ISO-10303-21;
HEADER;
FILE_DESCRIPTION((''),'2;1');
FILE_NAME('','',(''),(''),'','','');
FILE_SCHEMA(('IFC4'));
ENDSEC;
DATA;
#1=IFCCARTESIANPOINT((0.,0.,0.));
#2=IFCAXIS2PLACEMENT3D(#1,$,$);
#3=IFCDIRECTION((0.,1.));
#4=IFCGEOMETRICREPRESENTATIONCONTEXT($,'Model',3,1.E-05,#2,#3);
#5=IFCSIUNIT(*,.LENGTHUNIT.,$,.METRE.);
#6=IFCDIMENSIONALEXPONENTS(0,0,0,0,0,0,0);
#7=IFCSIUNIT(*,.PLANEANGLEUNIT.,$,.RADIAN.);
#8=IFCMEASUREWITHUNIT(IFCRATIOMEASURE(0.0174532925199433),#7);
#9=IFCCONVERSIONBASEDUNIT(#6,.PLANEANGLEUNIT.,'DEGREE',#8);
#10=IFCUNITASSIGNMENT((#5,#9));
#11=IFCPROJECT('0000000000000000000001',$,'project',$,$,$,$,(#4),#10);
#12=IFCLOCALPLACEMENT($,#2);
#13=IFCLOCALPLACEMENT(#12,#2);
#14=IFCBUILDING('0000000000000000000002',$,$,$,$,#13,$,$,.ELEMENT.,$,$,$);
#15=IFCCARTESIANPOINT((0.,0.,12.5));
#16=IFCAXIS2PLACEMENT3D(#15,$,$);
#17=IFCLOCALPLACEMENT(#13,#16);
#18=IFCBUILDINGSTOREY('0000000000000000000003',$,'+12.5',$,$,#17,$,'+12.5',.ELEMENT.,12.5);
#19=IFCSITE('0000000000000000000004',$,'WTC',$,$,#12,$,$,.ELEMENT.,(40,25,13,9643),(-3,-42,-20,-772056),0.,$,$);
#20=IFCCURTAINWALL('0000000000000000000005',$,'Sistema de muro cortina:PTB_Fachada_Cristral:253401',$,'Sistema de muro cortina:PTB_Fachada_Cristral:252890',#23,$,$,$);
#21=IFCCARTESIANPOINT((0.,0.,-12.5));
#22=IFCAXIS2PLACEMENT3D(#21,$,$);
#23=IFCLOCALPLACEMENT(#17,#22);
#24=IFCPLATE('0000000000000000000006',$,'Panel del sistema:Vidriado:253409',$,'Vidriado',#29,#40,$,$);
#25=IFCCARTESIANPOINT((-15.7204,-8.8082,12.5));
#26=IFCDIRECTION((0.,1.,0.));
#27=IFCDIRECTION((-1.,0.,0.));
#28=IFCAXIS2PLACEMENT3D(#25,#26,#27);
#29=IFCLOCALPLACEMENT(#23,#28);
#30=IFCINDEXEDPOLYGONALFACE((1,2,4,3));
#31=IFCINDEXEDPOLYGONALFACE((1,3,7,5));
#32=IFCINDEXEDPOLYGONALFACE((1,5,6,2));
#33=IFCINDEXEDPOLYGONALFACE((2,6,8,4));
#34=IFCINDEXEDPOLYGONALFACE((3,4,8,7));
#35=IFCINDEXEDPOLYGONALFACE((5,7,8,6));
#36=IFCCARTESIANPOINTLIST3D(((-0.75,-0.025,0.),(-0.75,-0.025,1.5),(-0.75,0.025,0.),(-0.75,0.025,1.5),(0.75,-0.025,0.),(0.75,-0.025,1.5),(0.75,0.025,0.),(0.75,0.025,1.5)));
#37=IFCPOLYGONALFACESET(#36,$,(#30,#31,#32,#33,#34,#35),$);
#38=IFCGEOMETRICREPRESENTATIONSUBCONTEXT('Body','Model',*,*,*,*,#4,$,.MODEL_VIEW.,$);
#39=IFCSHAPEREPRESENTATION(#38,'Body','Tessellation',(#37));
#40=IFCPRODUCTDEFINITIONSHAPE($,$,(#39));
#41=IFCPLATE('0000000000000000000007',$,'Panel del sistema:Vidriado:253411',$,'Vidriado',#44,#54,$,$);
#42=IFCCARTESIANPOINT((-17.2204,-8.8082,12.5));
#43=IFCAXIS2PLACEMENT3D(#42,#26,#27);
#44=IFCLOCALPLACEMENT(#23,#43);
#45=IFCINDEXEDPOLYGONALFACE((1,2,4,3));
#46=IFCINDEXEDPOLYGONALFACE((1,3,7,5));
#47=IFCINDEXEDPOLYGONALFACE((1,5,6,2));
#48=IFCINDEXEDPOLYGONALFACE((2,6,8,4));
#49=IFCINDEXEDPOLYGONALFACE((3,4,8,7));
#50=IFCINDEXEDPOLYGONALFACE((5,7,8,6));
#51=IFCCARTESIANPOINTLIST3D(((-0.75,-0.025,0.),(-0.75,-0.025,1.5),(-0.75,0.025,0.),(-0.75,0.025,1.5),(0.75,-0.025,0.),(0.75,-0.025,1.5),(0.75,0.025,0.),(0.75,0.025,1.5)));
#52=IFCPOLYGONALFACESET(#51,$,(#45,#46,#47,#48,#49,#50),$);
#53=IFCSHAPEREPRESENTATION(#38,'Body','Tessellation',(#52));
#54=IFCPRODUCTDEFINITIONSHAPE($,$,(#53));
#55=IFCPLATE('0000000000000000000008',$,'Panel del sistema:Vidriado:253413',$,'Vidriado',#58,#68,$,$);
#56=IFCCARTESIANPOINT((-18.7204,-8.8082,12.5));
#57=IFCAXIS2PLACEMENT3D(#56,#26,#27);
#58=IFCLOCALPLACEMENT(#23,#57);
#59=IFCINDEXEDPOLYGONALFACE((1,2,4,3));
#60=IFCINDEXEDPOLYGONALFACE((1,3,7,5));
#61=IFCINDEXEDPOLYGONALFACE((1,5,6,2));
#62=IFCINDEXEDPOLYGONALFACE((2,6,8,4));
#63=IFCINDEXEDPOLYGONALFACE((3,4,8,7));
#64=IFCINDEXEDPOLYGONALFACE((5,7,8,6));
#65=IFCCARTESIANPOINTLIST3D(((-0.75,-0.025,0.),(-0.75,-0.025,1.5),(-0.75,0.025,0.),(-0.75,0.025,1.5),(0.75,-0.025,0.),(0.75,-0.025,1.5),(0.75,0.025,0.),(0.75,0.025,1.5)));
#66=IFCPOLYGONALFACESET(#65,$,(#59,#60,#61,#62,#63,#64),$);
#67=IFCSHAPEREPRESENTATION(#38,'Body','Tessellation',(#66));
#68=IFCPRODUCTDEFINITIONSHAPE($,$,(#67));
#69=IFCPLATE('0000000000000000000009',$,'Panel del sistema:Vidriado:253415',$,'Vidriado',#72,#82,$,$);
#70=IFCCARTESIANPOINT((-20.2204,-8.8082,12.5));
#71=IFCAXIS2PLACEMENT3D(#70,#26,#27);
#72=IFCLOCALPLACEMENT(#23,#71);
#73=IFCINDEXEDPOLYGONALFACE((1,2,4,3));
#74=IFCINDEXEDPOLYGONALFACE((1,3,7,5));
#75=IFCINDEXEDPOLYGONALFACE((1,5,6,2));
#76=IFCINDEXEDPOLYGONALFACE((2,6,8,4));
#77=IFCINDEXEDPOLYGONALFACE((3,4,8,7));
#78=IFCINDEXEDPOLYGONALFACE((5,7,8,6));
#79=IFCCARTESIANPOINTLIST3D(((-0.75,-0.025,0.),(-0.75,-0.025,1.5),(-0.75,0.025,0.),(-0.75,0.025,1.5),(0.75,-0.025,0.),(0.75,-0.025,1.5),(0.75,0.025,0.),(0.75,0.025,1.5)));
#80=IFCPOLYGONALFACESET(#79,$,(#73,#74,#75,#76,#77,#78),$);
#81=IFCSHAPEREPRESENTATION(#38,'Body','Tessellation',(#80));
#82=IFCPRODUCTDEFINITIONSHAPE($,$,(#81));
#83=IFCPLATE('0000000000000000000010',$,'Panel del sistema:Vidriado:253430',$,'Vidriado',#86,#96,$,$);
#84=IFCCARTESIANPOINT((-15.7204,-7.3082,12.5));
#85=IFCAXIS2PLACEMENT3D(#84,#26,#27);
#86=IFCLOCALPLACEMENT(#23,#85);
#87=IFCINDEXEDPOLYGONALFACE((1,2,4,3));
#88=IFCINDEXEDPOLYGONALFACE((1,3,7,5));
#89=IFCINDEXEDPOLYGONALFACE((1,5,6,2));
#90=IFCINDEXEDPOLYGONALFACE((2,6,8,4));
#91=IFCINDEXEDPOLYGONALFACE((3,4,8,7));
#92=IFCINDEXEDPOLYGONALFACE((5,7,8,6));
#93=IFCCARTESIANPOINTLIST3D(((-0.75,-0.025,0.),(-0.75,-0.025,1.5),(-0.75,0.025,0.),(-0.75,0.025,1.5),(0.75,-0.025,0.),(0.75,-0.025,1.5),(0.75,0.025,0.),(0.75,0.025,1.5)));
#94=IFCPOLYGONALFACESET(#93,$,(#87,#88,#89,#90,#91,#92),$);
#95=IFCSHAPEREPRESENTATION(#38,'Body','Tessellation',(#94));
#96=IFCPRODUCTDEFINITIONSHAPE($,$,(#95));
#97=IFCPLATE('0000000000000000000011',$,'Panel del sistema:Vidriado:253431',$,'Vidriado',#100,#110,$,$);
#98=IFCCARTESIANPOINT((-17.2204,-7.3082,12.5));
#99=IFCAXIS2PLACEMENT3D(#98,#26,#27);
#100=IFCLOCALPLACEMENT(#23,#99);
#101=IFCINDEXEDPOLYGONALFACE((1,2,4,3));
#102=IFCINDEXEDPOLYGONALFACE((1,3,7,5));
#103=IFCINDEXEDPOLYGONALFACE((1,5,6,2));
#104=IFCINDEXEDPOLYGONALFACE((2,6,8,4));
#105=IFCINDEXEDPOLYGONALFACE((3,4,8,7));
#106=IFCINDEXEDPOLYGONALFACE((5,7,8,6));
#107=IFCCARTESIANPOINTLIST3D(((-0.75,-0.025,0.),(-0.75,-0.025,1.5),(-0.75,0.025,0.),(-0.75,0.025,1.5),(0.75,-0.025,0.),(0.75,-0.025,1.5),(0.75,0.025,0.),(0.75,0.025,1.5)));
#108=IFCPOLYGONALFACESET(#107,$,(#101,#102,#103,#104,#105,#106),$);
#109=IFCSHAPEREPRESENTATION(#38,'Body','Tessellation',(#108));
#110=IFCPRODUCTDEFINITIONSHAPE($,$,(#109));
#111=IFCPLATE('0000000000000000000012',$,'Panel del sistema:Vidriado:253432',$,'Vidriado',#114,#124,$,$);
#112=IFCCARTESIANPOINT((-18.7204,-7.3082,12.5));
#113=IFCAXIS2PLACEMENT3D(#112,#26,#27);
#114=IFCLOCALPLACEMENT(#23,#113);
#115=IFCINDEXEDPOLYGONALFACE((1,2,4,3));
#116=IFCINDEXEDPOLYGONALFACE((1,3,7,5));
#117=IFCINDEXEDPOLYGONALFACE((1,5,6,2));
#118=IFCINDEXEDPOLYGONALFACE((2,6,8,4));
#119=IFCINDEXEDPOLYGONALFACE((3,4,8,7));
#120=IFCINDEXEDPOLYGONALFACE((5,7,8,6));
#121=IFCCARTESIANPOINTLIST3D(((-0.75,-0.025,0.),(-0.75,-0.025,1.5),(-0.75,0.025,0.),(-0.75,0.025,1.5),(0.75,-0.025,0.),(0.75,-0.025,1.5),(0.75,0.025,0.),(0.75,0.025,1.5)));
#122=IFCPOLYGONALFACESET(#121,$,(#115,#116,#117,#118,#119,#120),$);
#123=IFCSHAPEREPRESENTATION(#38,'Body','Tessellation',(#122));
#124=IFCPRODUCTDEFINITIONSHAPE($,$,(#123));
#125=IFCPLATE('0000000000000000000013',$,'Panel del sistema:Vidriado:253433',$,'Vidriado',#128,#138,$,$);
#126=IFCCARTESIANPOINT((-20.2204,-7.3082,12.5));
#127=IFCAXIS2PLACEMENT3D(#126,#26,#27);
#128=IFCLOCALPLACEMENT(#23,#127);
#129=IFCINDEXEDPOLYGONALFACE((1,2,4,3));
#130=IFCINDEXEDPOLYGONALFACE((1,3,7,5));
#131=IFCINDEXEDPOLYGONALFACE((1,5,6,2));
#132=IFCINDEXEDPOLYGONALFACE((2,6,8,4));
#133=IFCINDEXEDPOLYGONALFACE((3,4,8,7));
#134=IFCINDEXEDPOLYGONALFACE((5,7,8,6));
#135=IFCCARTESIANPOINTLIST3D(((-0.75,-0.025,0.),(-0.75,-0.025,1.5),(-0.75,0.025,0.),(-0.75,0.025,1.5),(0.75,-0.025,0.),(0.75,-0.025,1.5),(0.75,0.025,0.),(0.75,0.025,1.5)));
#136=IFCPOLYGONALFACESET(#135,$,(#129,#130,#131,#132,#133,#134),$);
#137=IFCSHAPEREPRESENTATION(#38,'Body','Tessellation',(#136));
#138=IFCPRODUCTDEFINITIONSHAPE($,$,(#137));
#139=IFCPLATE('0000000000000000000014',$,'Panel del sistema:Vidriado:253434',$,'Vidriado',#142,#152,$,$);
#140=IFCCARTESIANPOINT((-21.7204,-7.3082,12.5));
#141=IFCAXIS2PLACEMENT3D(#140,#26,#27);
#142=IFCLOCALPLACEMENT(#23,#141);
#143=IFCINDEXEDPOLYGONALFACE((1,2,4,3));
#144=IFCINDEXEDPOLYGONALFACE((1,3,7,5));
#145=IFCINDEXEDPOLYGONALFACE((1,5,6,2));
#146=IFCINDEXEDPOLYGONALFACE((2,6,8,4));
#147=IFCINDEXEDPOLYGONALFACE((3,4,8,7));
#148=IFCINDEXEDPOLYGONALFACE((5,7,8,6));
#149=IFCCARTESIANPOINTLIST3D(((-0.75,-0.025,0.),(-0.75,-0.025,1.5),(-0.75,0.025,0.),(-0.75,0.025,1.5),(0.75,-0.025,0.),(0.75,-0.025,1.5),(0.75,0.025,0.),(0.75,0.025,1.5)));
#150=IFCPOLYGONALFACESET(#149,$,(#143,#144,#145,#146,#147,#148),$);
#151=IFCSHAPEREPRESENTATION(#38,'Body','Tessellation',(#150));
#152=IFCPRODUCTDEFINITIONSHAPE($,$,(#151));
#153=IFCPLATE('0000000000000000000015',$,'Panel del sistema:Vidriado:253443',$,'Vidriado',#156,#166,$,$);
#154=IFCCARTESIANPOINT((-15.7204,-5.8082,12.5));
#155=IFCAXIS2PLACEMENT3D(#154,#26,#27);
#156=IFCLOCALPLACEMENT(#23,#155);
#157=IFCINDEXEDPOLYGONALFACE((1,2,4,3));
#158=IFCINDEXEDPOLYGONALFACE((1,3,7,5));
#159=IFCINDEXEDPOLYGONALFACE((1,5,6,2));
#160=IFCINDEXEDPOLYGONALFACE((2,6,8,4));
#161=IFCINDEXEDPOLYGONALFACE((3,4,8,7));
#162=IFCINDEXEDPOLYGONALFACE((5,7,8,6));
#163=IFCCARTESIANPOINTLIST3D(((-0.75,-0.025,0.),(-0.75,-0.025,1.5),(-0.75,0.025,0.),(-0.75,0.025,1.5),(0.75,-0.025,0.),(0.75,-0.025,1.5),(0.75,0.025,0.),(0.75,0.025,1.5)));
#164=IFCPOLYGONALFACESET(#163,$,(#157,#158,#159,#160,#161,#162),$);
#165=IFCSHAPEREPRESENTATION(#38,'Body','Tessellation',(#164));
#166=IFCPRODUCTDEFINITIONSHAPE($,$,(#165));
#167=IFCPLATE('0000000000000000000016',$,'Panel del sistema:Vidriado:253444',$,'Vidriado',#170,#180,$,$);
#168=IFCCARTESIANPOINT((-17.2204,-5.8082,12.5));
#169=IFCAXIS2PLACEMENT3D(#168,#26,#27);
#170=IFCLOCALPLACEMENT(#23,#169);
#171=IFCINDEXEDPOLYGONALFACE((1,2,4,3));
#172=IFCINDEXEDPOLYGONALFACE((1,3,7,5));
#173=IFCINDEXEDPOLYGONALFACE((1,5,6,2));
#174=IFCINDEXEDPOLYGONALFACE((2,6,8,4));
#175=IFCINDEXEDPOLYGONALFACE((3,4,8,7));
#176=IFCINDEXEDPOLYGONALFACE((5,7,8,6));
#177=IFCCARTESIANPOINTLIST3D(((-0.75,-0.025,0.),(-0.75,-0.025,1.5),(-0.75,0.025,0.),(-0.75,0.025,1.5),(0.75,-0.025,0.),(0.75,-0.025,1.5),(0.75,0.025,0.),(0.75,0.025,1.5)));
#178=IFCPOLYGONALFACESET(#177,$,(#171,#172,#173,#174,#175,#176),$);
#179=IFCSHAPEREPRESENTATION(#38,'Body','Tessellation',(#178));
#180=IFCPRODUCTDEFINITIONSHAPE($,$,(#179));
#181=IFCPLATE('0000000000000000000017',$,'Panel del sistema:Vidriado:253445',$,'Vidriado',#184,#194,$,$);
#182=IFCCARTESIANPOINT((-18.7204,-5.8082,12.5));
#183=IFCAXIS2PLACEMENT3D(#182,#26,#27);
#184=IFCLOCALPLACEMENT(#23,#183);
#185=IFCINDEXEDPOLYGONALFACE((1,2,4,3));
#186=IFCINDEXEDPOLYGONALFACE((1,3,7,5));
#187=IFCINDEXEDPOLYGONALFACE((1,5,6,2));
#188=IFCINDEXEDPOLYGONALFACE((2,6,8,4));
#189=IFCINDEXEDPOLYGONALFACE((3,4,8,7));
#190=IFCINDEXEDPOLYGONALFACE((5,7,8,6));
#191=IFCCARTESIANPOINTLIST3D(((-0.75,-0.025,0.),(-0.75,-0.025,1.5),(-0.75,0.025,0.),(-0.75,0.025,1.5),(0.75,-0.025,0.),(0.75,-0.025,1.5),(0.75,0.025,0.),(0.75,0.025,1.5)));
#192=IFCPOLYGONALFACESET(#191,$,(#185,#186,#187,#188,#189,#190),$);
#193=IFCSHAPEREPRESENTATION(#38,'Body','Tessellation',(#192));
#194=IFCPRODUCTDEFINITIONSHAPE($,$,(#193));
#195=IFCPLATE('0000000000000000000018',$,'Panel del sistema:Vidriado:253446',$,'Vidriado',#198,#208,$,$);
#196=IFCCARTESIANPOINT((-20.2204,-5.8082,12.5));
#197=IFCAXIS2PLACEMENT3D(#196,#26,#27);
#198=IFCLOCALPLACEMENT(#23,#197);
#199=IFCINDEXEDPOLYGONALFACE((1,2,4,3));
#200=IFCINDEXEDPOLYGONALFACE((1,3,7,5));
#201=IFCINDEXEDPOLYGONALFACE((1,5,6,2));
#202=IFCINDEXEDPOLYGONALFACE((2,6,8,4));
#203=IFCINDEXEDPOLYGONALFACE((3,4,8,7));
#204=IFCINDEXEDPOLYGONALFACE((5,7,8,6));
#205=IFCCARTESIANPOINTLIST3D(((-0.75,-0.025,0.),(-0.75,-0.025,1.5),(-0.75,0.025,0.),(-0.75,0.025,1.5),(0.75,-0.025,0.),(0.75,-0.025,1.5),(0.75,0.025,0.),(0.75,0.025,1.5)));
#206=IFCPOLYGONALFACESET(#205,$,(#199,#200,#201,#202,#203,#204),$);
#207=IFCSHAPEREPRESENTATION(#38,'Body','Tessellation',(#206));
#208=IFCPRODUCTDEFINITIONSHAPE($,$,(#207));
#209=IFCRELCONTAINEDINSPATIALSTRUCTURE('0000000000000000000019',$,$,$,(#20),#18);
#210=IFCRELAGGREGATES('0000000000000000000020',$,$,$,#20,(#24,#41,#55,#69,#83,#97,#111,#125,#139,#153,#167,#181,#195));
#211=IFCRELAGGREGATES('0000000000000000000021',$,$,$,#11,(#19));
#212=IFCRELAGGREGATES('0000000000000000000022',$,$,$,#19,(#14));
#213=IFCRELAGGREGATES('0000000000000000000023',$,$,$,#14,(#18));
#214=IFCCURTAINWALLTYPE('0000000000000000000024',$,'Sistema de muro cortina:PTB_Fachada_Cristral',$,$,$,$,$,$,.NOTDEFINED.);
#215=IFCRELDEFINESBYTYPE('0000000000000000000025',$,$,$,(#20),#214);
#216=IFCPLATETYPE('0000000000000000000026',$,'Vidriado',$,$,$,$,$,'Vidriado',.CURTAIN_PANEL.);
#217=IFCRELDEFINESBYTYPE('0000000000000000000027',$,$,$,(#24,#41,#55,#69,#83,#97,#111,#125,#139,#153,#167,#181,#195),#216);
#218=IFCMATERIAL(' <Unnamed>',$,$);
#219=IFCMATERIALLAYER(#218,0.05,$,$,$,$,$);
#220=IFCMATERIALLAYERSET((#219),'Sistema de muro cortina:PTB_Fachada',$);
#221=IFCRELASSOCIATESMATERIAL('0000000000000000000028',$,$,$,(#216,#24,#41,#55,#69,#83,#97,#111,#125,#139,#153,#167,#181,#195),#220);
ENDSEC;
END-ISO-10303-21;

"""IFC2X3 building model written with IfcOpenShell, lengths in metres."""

from ifc_helpers import new_model, entity, si_unit, converted_unit, direction, frame, origin, origin_2d_with_axis, place, context, subcontext, project, spatial, rectangle, extrude, source, transform, mapped, material, layer, layer_set, layer_usage, type_object, type_shapes, element, aggregate, save


model = new_model("IFC2X3")

# Units and contexts
model_context = context("Model", 3, precision=1e-05, world=origin(), true_north=direction((0.0, 1.0)))
body_context = subcontext(model_context, "Body", "Model", "MODEL_VIEW")
ifc_project = project(units=[si_unit("LENGTHUNIT", "METRE"), converted_unit("PLANEANGLEUNIT", "DEGREE", entity("IfcRatioMeasure", 0.0174532925199433), si_unit("PLANEANGLEUNIT", "RADIAN"), dimensions=[0, 0, 0, 0, 0, 0, 0])], contexts=[model_context])

# Site, building, storey
site_placement = place(None, origin())
site = spatial("IfcSite", under=ifc_project, at=site_placement, Name="WTC", CompositionType="ELEMENT", RefLatitude=(40, 25, 13, 9643), RefLongitude=(-3, -42, -20, -772056), RefElevation=0.0)
building_placement = place(site_placement, origin())
building = spatial("IfcBuilding", under=site, at=building_placement, CompositionType="ELEMENT")
storey_placement = place(building_placement, frame((0.0, 0.0, 12.5)))
storey = spatial("IfcBuildingStorey", under=building, at=storey_placement, Name="+12.5", LongName="+12.5", CompositionType="ELEMENT", Elevation=12.5)

# Curtain wall, plates
curtain_wall_type = type_object("IfcCurtainWallType", Name="Sistema de muro cortina:PTB_Fachada_Cristral", PredefinedType="NOTDEFINED")
curtain_wall_placement = place(storey_placement, frame((0.0, 0.0, -12.5)))
curtain_wall = element("IfcCurtainWall", 1, at=curtain_wall_placement, inside=storey, type_object=curtain_wall_type, Name="Sistema de muro cortina:PTB_Fachada_Cristral:253401", ObjectType="Sistema de muro cortina:PTB_Fachada_Cristral:252890")
ifc_material = material(Name=" <Unnamed>")
ifc_layer = layer(ifc_material, 0.05)
ifc_layer_set = layer_set([ifc_layer], Name="Sistema de muro cortina:PTB_Fachada")
ifc_layer_usage_1 = layer_usage(ifc_layer_set, "AXIS3", "POSITIVE", 0.0)
plate_type = type_object("IfcPlateType", Name="Vidriado", ElementType="Vidriado", PredefinedType="CURTAIN_PANEL", material=ifc_layer_set)
shared_shape = source(origin(), body_context, "Body", "SweptSolid", [
    extrude(rectangle(XDim=0.05, YDim=1.5, at=origin_2d_with_axis()), frame((0.0, 0.0, 0.0), z_axis=(0.0, 0.0, 1.0), x_axis=(0.0, 1.0, 0.0)), (0.0, 0.0, 1.0), 1.5),
])
type_shapes(plate_type, [shared_shape])
plate_1_placement = place(curtain_wall_placement, frame((-15.7204, -8.8082, 12.5), z_axis=(0.0, 1.0, 0.0), x_axis=(-1.0, 0.0, 0.0)))
plate_1 = element("IfcPlate", 2, at=plate_1_placement, type_object=plate_type, material=ifc_layer_usage_1, Name="Panel del sistema:Vidriado:253409", ObjectType="Vidriado", context=body_context, shape_type="MappedRepresentation", body=[
    mapped(shared_shape, transform((0.0, 0.0, 0.0), scale=1.0)),
])
ifc_layer_usage_2 = layer_usage(ifc_layer_set, "AXIS3", "POSITIVE", 0.0)
plate_2_placement = place(curtain_wall_placement, frame((-17.2204, -8.8082, 12.5), z_axis=(0.0, 1.0, 0.0), x_axis=(-1.0, 0.0, 0.0)))
plate_2 = element("IfcPlate", 3, at=plate_2_placement, type_object=plate_type, material=ifc_layer_usage_2, Name="Panel del sistema:Vidriado:253411", ObjectType="Vidriado", context=body_context, shape_type="MappedRepresentation", body=[
    mapped(shared_shape, transform((0.0, 0.0, 0.0), scale=1.0)),
])
ifc_layer_usage_3 = layer_usage(ifc_layer_set, "AXIS3", "POSITIVE", 0.0)
plate_3_placement = place(curtain_wall_placement, frame((-18.7204, -8.8082, 12.5), z_axis=(0.0, 1.0, 0.0), x_axis=(-1.0, 0.0, 0.0)))
plate_3 = element("IfcPlate", 4, at=plate_3_placement, type_object=plate_type, material=ifc_layer_usage_3, Name="Panel del sistema:Vidriado:253413", ObjectType="Vidriado", context=body_context, shape_type="MappedRepresentation", body=[
    mapped(shared_shape, transform((0.0, 0.0, 0.0), scale=1.0)),
])
ifc_layer_usage_4 = layer_usage(ifc_layer_set, "AXIS3", "POSITIVE", 0.0)
plate_4_placement = place(curtain_wall_placement, frame((-20.2204, -8.8082, 12.5), z_axis=(0.0, 1.0, 0.0), x_axis=(-1.0, 0.0, 0.0)))
plate_4 = element("IfcPlate", 5, at=plate_4_placement, type_object=plate_type, material=ifc_layer_usage_4, Name="Panel del sistema:Vidriado:253415", ObjectType="Vidriado", context=body_context, shape_type="MappedRepresentation", body=[
    mapped(shared_shape, transform((0.0, 0.0, 0.0), scale=1.0)),
])
ifc_layer_usage_5 = layer_usage(ifc_layer_set, "AXIS3", "POSITIVE", 0.0)
plate_5_placement = place(curtain_wall_placement, frame((-15.7204, -7.3082, 12.5), z_axis=(0.0, 1.0, 0.0), x_axis=(-1.0, 0.0, 0.0)))
plate_5 = element("IfcPlate", 6, at=plate_5_placement, type_object=plate_type, material=ifc_layer_usage_5, Name="Panel del sistema:Vidriado:253430", ObjectType="Vidriado", context=body_context, shape_type="MappedRepresentation", body=[
    mapped(shared_shape, transform((0.0, 0.0, 0.0), scale=1.0)),
])
ifc_layer_usage_6 = layer_usage(ifc_layer_set, "AXIS3", "POSITIVE", 0.0)
plate_6_placement = place(curtain_wall_placement, frame((-17.2204, -7.3082, 12.5), z_axis=(0.0, 1.0, 0.0), x_axis=(-1.0, 0.0, 0.0)))
plate_6 = element("IfcPlate", 7, at=plate_6_placement, type_object=plate_type, material=ifc_layer_usage_6, Name="Panel del sistema:Vidriado:253431", ObjectType="Vidriado", context=body_context, shape_type="MappedRepresentation", body=[
    mapped(shared_shape, transform((0.0, 0.0, 0.0), scale=1.0)),
])
ifc_layer_usage_7 = layer_usage(ifc_layer_set, "AXIS3", "POSITIVE", 0.0)
plate_7_placement = place(curtain_wall_placement, frame((-18.7204, -7.3082, 12.5), z_axis=(0.0, 1.0, 0.0), x_axis=(-1.0, 0.0, 0.0)))
plate_7 = element("IfcPlate", 8, at=plate_7_placement, type_object=plate_type, material=ifc_layer_usage_7, Name="Panel del sistema:Vidriado:253432", ObjectType="Vidriado", context=body_context, shape_type="MappedRepresentation", body=[
    mapped(shared_shape, transform((0.0, 0.0, 0.0), scale=1.0)),
])
ifc_layer_usage_8 = layer_usage(ifc_layer_set, "AXIS3", "POSITIVE", 0.0)
plate_8_placement = place(curtain_wall_placement, frame((-20.2204, -7.3082, 12.5), z_axis=(0.0, 1.0, 0.0), x_axis=(-1.0, 0.0, 0.0)))
plate_8 = element("IfcPlate", 9, at=plate_8_placement, type_object=plate_type, material=ifc_layer_usage_8, Name="Panel del sistema:Vidriado:253433", ObjectType="Vidriado", context=body_context, shape_type="MappedRepresentation", body=[
    mapped(shared_shape, transform((0.0, 0.0, 0.0), scale=1.0)),
])
ifc_layer_usage_9 = layer_usage(ifc_layer_set, "AXIS3", "POSITIVE", 0.0)
plate_9_placement = place(curtain_wall_placement, frame((-21.7204, -7.3082, 12.5), z_axis=(0.0, 1.0, 0.0), x_axis=(-1.0, 0.0, 0.0)))
plate_9 = element("IfcPlate", 10, at=plate_9_placement, type_object=plate_type, material=ifc_layer_usage_9, Name="Panel del sistema:Vidriado:253434", ObjectType="Vidriado", context=body_context, shape_type="MappedRepresentation", body=[
    mapped(shared_shape, transform((0.0, 0.0, 0.0), scale=1.0)),
])
ifc_layer_usage_10 = layer_usage(ifc_layer_set, "AXIS3", "POSITIVE", 0.0)
plate_10_placement = place(curtain_wall_placement, frame((-15.7204, -5.8082, 12.5), z_axis=(0.0, 1.0, 0.0), x_axis=(-1.0, 0.0, 0.0)))
plate_10 = element("IfcPlate", 11, at=plate_10_placement, type_object=plate_type, material=ifc_layer_usage_10, Name="Panel del sistema:Vidriado:253443", ObjectType="Vidriado", context=body_context, shape_type="MappedRepresentation", body=[
    mapped(shared_shape, transform((0.0, 0.0, 0.0), scale=1.0)),
])
ifc_layer_usage_11 = layer_usage(ifc_layer_set, "AXIS3", "POSITIVE", 0.0)
plate_11_placement = place(curtain_wall_placement, frame((-17.2204, -5.8082, 12.5), z_axis=(0.0, 1.0, 0.0), x_axis=(-1.0, 0.0, 0.0)))
plate_11 = element("IfcPlate", 12, at=plate_11_placement, type_object=plate_type, material=ifc_layer_usage_11, Name="Panel del sistema:Vidriado:253444", ObjectType="Vidriado", context=body_context, shape_type="MappedRepresentation", body=[
    mapped(shared_shape, transform((0.0, 0.0, 0.0), scale=1.0)),
])
ifc_layer_usage_12 = layer_usage(ifc_layer_set, "AXIS3", "POSITIVE", 0.0)
plate_12_placement = place(curtain_wall_placement, frame((-18.7204, -5.8082, 12.5), z_axis=(0.0, 1.0, 0.0), x_axis=(-1.0, 0.0, 0.0)))
plate_12 = element("IfcPlate", 13, at=plate_12_placement, type_object=plate_type, material=ifc_layer_usage_12, Name="Panel del sistema:Vidriado:253445", ObjectType="Vidriado", context=body_context, shape_type="MappedRepresentation", body=[
    mapped(shared_shape, transform((0.0, 0.0, 0.0), scale=1.0)),
])
ifc_layer_usage_13 = layer_usage(ifc_layer_set, "AXIS3", "POSITIVE", 0.0)
plate_13_placement = place(curtain_wall_placement, frame((-20.2204, -5.8082, 12.5), z_axis=(0.0, 1.0, 0.0), x_axis=(-1.0, 0.0, 0.0)))
plate_13 = element("IfcPlate", 14, at=plate_13_placement, type_object=plate_type, material=ifc_layer_usage_13, Name="Panel del sistema:Vidriado:253446", ObjectType="Vidriado", context=body_context, shape_type="MappedRepresentation", body=[
    mapped(shared_shape, transform((0.0, 0.0, 0.0), scale=1.0)),
])
aggregate(curtain_wall, [plate_1, plate_2, plate_3, plate_4, plate_5, plate_6, plate_7, plate_8, plate_9, plate_10, plate_11, plate_12, plate_13])

save(model, "model.ifc")
